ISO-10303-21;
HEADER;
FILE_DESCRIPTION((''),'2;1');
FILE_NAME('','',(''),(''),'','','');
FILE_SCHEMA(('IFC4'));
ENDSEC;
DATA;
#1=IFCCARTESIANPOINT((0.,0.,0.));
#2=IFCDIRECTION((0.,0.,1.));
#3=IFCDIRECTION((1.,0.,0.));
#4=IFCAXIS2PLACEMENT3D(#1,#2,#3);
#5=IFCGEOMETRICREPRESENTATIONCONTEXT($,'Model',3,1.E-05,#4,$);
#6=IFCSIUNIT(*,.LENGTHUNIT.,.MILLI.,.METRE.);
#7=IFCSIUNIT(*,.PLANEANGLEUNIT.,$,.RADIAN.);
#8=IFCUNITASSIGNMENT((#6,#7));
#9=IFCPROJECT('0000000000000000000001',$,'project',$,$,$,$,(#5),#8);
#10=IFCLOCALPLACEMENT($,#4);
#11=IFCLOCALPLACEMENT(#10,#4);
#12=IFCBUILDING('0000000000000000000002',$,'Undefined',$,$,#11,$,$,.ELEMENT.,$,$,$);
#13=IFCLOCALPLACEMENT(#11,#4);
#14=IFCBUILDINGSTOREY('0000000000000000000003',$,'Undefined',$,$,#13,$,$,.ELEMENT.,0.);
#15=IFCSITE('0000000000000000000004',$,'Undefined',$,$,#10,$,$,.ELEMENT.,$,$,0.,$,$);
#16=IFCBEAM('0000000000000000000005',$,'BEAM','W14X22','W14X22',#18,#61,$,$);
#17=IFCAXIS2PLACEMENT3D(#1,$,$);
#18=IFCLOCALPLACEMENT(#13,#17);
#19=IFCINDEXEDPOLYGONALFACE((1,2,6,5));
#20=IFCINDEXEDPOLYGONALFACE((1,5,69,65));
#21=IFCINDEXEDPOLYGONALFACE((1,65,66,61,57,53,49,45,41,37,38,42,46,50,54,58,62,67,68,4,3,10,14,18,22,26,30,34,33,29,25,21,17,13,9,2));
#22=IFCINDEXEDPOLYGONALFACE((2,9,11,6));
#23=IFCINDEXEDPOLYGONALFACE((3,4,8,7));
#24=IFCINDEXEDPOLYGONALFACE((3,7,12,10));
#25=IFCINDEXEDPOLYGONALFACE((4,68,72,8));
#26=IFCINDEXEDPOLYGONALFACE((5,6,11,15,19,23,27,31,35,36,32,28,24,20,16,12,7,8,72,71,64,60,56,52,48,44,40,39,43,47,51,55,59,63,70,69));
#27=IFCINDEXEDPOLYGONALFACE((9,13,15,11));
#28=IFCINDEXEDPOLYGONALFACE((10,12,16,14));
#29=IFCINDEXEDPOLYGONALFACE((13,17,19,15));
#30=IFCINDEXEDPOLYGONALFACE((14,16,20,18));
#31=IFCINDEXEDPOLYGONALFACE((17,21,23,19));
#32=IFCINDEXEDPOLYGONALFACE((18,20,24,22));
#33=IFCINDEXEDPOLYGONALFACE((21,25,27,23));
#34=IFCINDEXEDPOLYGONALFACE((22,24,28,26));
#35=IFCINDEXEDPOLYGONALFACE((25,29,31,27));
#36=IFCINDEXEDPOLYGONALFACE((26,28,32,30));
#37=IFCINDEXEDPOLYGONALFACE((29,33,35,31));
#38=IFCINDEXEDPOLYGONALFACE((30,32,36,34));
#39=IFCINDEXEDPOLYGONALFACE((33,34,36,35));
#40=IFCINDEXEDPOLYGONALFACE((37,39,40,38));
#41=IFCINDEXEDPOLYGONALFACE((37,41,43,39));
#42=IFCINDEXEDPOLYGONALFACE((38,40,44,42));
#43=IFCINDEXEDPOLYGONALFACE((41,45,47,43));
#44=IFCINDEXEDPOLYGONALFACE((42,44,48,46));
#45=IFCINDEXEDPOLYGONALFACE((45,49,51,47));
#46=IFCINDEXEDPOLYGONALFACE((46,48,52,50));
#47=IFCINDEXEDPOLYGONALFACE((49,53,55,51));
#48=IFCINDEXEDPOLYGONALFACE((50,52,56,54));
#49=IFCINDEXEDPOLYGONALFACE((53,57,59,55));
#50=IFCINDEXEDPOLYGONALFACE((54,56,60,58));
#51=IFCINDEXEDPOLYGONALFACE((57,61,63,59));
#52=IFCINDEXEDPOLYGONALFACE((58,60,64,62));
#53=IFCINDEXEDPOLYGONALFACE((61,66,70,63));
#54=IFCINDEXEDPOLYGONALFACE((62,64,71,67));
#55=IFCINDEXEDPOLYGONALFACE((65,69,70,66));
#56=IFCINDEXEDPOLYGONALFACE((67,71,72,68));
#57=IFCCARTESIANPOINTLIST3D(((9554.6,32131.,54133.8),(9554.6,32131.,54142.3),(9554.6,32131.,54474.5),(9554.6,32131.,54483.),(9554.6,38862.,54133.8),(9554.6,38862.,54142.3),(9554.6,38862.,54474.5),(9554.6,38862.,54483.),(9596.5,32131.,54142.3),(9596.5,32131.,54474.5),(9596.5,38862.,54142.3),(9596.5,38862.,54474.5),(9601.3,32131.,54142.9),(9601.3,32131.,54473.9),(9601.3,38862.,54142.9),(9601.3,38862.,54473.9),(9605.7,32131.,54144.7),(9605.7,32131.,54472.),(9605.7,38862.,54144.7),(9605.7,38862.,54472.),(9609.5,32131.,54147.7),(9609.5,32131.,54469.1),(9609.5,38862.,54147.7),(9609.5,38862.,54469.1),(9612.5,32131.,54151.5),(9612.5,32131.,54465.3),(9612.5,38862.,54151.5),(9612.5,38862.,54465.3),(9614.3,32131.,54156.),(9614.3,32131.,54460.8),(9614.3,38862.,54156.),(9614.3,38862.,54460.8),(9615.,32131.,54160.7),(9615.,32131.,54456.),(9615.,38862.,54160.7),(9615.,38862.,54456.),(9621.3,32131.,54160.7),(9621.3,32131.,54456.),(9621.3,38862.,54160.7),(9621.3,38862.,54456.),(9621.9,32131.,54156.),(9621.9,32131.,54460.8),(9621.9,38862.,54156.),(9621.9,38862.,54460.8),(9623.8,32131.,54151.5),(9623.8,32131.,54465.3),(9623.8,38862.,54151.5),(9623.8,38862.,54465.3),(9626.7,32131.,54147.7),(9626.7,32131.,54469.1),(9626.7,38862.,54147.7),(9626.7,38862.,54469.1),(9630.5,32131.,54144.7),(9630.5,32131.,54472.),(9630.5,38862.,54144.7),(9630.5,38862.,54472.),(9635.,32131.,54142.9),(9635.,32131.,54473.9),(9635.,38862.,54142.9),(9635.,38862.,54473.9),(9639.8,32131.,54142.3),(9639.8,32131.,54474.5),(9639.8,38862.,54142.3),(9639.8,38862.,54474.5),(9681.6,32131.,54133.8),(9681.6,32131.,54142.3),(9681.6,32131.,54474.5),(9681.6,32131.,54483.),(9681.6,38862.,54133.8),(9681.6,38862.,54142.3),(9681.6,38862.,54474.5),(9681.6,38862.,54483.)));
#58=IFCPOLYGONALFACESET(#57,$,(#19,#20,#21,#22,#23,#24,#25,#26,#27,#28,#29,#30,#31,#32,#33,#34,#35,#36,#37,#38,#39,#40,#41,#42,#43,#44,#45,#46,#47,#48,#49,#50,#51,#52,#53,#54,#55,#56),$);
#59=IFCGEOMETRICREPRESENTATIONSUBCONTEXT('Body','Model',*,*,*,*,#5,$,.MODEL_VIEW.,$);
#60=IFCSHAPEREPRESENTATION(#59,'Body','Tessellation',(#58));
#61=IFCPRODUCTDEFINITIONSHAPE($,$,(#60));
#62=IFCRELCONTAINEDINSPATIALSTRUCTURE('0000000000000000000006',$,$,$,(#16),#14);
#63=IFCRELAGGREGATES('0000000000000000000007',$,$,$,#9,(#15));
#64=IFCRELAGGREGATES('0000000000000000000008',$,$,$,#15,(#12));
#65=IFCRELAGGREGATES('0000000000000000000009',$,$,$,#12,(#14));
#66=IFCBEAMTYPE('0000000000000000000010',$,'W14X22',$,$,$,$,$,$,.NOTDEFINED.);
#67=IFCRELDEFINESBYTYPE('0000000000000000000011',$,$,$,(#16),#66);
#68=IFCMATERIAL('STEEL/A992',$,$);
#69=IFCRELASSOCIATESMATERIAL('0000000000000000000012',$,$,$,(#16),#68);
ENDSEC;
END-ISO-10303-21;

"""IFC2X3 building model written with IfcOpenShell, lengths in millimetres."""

from ifc_helpers import new_model, si_unit, frame, origin_with_axes, origin_2d_with_axis, place, context, subcontext, project, spatial, i_section, extrude, material, type_object, element, save


model = new_model("IFC2X3")

# Units and contexts
model_context = context("Model", 3, precision=1e-05, world=origin_with_axes())
body_context = subcontext(model_context, "Body", "Model", "MODEL_VIEW")
ifc_project = project(units=[si_unit("LENGTHUNIT", "METRE", prefix="MILLI"), si_unit("PLANEANGLEUNIT", "RADIAN")], contexts=[model_context])

# Site, building, storey
site_placement = place(None, origin_with_axes())
site = spatial("IfcSite", under=ifc_project, at=site_placement, Name="Undefined", CompositionType="ELEMENT", RefElevation=0.0)
building_placement = place(site_placement, origin_with_axes())
building = spatial("IfcBuilding", under=site, at=building_placement, Name="Undefined", CompositionType="ELEMENT")
storey_placement = place(building_placement, origin_with_axes())
storey = spatial("IfcBuildingStorey", under=building, at=storey_placement, Name="Undefined", CompositionType="ELEMENT", Elevation=0.0)

# Shared definitions
ifc_material_1 = material(Name="STEEL/A992")

# Beam
beam_type_1 = type_object("IfcBeamType", Name="W14X22", PredefinedType="NOTDEFINED")
for number, where, z_axis, x_axis, name in (
    (1, (9618.1, 32131.0, 54308.4), (0.0, 0.0, 1.0), (0.0, 1.0, 0.0), "BEAM"),
):
    element("IfcBeam", number, at=place(storey_placement, frame(where, z_axis=z_axis, x_axis=x_axis)), inside=storey, type_object=beam_type_1, material=ifc_material_1, Name=name, Description="W14X22", ObjectType="W14X22", context=body_context, shape_type="SweptSolid", body=[
        extrude(i_section(OverallWidth=127.0, OverallDepth=349.2, WebThickness=6.3, FlangeThickness=8.5, FilletRadius=18.5, at=origin_2d_with_axis()), frame((6731.0, 0.0, 0.0), z_axis=(-1.0, 0.0, 0.0), x_axis=(0.0, -1.0, 0.0)), (0.0, 0.0, 1.0), 6731.0),
    ])

save(model, "model.ifc")
